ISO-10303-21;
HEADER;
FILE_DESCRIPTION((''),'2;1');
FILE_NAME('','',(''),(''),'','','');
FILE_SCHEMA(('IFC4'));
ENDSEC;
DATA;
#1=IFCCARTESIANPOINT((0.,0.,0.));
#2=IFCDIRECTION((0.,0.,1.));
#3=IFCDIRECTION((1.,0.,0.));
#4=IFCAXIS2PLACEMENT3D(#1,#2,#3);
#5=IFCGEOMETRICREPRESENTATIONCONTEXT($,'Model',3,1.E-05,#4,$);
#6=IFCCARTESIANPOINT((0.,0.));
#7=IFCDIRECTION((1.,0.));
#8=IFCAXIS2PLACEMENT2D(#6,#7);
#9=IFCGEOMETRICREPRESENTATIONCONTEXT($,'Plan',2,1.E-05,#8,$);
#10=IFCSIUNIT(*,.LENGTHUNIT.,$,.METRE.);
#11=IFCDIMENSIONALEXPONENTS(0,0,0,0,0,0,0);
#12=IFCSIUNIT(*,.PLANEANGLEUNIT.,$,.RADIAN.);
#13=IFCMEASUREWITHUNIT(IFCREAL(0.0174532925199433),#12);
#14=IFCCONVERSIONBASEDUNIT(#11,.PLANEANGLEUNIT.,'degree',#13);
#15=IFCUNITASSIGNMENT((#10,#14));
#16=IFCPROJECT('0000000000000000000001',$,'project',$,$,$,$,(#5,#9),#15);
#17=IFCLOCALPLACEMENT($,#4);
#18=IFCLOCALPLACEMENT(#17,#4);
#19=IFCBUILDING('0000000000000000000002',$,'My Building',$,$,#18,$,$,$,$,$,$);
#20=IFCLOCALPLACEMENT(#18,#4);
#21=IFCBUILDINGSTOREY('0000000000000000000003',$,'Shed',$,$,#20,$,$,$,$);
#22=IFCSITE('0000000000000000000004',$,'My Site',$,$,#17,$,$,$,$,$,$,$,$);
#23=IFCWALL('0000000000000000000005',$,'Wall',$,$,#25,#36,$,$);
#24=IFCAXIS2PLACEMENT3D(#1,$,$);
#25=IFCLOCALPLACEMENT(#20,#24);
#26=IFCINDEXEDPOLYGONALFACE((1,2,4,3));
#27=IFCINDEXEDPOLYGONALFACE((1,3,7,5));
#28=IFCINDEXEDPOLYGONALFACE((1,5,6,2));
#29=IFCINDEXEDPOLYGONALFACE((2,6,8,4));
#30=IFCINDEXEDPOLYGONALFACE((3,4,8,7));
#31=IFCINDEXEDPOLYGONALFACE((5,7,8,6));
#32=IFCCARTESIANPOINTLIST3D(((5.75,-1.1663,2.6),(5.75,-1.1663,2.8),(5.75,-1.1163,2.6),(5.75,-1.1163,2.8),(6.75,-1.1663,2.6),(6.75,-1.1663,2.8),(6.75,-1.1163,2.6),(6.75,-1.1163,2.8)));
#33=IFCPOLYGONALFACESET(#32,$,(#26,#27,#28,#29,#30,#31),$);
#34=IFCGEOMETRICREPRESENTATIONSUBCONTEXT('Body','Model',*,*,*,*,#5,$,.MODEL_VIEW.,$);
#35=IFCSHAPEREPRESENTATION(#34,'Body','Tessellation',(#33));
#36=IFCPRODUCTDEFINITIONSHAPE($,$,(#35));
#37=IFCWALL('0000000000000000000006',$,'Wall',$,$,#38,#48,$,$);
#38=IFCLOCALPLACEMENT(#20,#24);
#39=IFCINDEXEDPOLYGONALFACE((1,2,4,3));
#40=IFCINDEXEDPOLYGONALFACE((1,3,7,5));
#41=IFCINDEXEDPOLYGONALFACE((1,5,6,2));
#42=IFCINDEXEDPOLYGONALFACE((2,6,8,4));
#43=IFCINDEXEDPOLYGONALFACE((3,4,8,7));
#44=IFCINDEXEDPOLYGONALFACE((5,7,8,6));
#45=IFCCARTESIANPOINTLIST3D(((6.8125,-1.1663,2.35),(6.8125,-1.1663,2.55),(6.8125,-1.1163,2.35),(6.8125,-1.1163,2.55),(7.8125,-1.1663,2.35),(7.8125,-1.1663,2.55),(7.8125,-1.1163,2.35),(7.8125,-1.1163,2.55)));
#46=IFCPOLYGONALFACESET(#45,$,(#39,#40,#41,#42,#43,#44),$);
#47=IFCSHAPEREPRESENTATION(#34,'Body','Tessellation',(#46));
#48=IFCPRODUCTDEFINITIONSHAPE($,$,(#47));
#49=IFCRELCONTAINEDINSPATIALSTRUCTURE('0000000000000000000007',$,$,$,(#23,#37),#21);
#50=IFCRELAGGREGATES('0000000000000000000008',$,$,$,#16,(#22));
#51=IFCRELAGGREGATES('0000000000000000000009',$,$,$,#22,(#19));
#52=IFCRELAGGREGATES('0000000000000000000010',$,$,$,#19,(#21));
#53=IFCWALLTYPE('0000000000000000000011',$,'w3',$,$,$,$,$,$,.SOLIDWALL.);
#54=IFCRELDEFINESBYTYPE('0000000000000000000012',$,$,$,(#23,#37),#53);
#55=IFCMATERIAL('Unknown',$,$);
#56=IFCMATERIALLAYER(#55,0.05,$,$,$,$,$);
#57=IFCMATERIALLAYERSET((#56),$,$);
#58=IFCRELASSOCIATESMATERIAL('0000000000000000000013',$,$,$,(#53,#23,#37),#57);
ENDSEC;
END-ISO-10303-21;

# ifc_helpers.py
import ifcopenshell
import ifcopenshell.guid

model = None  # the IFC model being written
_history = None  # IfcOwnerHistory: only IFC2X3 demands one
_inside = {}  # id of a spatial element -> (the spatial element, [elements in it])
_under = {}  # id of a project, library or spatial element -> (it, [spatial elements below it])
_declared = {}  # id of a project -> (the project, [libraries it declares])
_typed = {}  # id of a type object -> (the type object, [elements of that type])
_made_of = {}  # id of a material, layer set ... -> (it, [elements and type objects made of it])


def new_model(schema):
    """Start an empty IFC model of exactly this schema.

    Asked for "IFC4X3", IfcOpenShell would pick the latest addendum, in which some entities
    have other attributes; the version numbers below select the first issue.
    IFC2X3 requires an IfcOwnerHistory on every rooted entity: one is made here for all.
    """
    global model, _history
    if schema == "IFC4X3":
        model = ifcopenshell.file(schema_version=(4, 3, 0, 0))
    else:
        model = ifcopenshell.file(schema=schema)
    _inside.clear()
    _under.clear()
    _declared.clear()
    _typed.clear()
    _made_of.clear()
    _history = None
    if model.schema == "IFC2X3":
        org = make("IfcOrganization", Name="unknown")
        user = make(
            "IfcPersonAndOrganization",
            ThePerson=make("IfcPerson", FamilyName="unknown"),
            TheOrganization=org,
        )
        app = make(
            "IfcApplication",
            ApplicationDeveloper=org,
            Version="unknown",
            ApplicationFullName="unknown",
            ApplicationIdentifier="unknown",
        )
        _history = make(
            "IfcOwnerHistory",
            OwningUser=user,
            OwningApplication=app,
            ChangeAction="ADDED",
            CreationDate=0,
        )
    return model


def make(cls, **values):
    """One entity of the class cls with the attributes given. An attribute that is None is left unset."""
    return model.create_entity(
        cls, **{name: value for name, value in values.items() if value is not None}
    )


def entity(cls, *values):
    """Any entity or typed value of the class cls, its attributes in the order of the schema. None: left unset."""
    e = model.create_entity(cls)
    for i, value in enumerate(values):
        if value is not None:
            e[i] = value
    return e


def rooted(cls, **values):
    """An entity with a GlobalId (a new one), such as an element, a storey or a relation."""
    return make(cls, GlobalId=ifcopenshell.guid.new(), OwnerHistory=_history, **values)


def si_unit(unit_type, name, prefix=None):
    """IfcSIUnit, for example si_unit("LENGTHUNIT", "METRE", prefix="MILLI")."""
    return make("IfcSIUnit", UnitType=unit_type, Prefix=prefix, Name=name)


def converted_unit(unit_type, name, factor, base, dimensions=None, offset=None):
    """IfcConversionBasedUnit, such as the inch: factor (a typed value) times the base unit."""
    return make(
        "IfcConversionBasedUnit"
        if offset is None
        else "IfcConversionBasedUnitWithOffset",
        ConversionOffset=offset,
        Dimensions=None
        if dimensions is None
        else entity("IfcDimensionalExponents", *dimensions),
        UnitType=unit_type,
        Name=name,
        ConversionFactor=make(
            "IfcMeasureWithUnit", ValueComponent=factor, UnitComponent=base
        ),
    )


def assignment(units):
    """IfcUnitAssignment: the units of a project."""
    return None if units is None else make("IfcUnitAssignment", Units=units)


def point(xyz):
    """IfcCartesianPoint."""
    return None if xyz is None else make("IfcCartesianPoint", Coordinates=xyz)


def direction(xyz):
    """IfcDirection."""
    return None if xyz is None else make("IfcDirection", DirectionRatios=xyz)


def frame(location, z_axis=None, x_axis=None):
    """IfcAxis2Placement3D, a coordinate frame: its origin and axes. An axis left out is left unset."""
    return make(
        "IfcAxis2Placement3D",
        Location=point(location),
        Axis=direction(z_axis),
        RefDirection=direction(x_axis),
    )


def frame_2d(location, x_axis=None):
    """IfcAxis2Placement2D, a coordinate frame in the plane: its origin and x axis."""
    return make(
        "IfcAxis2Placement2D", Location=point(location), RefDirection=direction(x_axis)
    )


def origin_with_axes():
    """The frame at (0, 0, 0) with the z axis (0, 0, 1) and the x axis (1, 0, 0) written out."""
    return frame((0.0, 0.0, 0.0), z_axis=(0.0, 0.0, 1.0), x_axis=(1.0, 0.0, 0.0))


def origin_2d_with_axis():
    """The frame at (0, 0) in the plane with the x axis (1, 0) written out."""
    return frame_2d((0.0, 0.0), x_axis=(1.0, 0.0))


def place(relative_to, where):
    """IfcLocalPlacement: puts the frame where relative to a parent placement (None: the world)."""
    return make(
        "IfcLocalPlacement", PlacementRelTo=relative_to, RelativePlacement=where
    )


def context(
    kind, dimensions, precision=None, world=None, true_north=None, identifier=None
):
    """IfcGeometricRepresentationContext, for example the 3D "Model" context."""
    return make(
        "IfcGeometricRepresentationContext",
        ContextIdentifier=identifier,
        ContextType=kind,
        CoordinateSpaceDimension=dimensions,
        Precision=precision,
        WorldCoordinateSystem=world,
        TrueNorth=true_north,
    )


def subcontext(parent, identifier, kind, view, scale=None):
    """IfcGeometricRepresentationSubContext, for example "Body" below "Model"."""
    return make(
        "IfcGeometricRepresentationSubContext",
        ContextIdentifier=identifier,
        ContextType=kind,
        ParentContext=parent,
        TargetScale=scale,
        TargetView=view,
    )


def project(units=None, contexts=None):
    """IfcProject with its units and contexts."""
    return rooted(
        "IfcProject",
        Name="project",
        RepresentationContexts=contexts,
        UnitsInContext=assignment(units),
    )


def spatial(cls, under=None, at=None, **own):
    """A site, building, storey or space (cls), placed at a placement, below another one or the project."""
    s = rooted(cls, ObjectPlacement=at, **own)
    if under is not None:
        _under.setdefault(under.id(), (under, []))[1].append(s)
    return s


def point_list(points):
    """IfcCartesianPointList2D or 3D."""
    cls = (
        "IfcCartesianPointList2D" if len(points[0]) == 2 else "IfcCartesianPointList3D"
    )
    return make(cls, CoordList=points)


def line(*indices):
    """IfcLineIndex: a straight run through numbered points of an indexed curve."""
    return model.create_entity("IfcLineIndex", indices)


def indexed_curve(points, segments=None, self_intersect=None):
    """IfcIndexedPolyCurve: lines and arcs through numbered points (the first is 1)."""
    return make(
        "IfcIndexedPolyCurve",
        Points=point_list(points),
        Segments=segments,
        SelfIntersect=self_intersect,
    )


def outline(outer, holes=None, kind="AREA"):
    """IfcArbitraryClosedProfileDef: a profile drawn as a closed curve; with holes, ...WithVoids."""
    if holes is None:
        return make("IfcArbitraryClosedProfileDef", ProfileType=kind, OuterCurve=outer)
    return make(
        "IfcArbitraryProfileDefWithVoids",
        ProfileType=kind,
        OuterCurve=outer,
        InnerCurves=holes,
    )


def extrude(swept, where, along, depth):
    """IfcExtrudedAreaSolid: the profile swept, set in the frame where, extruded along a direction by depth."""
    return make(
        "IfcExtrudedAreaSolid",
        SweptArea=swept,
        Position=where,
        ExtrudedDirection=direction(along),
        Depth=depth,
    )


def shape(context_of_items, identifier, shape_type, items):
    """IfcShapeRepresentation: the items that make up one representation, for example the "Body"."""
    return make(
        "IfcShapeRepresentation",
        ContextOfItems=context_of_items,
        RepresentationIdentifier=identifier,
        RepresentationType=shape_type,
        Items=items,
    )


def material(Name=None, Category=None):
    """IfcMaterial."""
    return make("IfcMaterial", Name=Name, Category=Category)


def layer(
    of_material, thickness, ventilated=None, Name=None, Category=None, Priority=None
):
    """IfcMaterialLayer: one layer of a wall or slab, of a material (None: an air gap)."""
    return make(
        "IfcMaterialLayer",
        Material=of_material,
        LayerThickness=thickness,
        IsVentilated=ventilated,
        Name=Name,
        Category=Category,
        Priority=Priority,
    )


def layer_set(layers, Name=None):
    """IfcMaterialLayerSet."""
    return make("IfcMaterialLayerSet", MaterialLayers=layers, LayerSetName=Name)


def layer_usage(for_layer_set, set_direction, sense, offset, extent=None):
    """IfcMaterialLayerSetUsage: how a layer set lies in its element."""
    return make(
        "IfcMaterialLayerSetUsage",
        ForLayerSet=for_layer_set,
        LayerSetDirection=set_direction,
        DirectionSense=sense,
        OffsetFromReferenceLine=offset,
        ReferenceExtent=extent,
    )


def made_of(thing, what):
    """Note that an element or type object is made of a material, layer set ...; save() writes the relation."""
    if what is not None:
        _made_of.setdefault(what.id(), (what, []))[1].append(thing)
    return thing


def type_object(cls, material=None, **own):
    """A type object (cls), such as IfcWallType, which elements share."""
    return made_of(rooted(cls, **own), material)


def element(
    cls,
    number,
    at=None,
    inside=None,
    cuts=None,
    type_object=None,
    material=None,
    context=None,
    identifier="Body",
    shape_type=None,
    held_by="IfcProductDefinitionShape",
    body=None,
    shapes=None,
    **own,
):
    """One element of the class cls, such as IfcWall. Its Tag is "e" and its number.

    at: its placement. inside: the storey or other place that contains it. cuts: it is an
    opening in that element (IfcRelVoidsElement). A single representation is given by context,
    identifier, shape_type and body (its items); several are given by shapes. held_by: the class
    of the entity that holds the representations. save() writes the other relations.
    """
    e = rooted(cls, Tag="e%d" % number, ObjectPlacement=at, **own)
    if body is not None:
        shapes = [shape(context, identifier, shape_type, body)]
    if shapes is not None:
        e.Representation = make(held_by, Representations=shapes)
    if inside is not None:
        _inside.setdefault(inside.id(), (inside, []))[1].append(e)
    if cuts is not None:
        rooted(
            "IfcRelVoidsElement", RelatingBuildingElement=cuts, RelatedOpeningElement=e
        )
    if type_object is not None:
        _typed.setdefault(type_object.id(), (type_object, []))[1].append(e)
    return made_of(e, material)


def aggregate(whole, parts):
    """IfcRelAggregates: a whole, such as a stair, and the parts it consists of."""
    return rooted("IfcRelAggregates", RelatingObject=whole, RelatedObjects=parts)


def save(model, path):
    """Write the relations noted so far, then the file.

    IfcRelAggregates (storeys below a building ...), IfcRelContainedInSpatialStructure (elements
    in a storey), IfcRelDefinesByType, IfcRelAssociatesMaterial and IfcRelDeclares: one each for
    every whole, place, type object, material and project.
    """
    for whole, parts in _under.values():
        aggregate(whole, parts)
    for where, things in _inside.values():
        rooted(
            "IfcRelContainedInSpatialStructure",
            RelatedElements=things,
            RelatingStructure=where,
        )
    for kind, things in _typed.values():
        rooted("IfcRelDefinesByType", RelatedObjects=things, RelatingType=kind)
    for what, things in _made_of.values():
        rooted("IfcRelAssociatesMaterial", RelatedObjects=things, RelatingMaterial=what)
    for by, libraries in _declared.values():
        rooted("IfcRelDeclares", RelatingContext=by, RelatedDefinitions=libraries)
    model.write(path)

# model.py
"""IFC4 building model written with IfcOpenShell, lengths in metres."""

from ifc_helpers import new_model, entity, si_unit, converted_unit, frame, origin_with_axes, origin_2d_with_axis, place, context, subcontext, project, spatial, line, indexed_curve, outline, extrude, material, layer, layer_set, layer_usage, type_object, element, save


model = new_model("IFC4")

# Units and contexts
model_context = context("Model", 3, precision=1e-05, world=origin_with_axes())
plan_context = context("Plan", 2, precision=1e-05, world=origin_2d_with_axis())
body_context_1 = subcontext(model_context, "Body", "Model", "MODEL_VIEW")
ifc_project = project(units=[si_unit("LENGTHUNIT", "METRE"), converted_unit("PLANEANGLEUNIT", "degree", entity("IfcReal", 0.0174532925199433), si_unit("PLANEANGLEUNIT", "RADIAN"), dimensions=[0, 0, 0, 0, 0, 0, 0])], contexts=[model_context, plan_context])

# Site, building, storey
site_placement = place(None, origin_with_axes())
site = spatial("IfcSite", under=ifc_project, at=site_placement, Name="My Site")
building_placement = place(site_placement, origin_with_axes())
building = spatial("IfcBuilding", under=site, at=building_placement, Name="My Building")
storey_placement = place(building_placement, origin_with_axes())
storey = spatial("IfcBuildingStorey", under=building, at=storey_placement, Name="Shed")

# Shared definitions
ifc_material = material(Name="Unknown")

# Walls
ifc_layer_1 = layer(ifc_material, 0.05)
ifc_layer_set_1 = layer_set([ifc_layer_1])
wall_type_1 = type_object("IfcWallType", Name="w3", PredefinedType="SOLIDWALL", material=ifc_layer_set_1)
ifc_layer_usage_1 = layer_usage(ifc_layer_set_1, "AXIS2", "POSITIVE", 0.0)
wall_1_placement = place(storey_placement, frame((5.75, -1.1663, 2.6), z_axis=(0.0, 0.0, 1.0), x_axis=(1.0, 0.0, 0.0)))
element("IfcWall", 1, at=wall_1_placement, inside=storey, type_object=wall_type_1, material=ifc_layer_usage_1, Name="Wall", context=body_context_1, shape_type="SweptSolid", body=[
    extrude(outline(indexed_curve([(0.0, 0.0), (0.0, 0.05), (1.0, 0.05), (1.0, 0.0)], segments=[line(1, 2, 3, 4, 1)])), origin_with_axes(), (0.0, 0.0, 1.0), 0.2),
])
ifc_layer_usage_2 = layer_usage(ifc_layer_set_1, "AXIS2", "POSITIVE", 0.0)
wall_2_placement = place(storey_placement, frame((6.8125, -1.1663, 2.35), z_axis=(0.0, 0.0, 1.0), x_axis=(1.0, 0.0, 0.0)))
element("IfcWall", 2, at=wall_2_placement, inside=storey, type_object=wall_type_1, material=ifc_layer_usage_2, Name="Wall", context=body_context_1, shape_type="SweptSolid", body=[
    extrude(outline(indexed_curve([(0.0, 0.0), (0.0, 0.05), (1.0, 0.05), (1.0, 0.0)], segments=[line(1, 2, 3, 4, 1)])), origin_with_axes(), (0.0, 0.0, 1.0), 0.2),
])

save(model, "model.ifc")
